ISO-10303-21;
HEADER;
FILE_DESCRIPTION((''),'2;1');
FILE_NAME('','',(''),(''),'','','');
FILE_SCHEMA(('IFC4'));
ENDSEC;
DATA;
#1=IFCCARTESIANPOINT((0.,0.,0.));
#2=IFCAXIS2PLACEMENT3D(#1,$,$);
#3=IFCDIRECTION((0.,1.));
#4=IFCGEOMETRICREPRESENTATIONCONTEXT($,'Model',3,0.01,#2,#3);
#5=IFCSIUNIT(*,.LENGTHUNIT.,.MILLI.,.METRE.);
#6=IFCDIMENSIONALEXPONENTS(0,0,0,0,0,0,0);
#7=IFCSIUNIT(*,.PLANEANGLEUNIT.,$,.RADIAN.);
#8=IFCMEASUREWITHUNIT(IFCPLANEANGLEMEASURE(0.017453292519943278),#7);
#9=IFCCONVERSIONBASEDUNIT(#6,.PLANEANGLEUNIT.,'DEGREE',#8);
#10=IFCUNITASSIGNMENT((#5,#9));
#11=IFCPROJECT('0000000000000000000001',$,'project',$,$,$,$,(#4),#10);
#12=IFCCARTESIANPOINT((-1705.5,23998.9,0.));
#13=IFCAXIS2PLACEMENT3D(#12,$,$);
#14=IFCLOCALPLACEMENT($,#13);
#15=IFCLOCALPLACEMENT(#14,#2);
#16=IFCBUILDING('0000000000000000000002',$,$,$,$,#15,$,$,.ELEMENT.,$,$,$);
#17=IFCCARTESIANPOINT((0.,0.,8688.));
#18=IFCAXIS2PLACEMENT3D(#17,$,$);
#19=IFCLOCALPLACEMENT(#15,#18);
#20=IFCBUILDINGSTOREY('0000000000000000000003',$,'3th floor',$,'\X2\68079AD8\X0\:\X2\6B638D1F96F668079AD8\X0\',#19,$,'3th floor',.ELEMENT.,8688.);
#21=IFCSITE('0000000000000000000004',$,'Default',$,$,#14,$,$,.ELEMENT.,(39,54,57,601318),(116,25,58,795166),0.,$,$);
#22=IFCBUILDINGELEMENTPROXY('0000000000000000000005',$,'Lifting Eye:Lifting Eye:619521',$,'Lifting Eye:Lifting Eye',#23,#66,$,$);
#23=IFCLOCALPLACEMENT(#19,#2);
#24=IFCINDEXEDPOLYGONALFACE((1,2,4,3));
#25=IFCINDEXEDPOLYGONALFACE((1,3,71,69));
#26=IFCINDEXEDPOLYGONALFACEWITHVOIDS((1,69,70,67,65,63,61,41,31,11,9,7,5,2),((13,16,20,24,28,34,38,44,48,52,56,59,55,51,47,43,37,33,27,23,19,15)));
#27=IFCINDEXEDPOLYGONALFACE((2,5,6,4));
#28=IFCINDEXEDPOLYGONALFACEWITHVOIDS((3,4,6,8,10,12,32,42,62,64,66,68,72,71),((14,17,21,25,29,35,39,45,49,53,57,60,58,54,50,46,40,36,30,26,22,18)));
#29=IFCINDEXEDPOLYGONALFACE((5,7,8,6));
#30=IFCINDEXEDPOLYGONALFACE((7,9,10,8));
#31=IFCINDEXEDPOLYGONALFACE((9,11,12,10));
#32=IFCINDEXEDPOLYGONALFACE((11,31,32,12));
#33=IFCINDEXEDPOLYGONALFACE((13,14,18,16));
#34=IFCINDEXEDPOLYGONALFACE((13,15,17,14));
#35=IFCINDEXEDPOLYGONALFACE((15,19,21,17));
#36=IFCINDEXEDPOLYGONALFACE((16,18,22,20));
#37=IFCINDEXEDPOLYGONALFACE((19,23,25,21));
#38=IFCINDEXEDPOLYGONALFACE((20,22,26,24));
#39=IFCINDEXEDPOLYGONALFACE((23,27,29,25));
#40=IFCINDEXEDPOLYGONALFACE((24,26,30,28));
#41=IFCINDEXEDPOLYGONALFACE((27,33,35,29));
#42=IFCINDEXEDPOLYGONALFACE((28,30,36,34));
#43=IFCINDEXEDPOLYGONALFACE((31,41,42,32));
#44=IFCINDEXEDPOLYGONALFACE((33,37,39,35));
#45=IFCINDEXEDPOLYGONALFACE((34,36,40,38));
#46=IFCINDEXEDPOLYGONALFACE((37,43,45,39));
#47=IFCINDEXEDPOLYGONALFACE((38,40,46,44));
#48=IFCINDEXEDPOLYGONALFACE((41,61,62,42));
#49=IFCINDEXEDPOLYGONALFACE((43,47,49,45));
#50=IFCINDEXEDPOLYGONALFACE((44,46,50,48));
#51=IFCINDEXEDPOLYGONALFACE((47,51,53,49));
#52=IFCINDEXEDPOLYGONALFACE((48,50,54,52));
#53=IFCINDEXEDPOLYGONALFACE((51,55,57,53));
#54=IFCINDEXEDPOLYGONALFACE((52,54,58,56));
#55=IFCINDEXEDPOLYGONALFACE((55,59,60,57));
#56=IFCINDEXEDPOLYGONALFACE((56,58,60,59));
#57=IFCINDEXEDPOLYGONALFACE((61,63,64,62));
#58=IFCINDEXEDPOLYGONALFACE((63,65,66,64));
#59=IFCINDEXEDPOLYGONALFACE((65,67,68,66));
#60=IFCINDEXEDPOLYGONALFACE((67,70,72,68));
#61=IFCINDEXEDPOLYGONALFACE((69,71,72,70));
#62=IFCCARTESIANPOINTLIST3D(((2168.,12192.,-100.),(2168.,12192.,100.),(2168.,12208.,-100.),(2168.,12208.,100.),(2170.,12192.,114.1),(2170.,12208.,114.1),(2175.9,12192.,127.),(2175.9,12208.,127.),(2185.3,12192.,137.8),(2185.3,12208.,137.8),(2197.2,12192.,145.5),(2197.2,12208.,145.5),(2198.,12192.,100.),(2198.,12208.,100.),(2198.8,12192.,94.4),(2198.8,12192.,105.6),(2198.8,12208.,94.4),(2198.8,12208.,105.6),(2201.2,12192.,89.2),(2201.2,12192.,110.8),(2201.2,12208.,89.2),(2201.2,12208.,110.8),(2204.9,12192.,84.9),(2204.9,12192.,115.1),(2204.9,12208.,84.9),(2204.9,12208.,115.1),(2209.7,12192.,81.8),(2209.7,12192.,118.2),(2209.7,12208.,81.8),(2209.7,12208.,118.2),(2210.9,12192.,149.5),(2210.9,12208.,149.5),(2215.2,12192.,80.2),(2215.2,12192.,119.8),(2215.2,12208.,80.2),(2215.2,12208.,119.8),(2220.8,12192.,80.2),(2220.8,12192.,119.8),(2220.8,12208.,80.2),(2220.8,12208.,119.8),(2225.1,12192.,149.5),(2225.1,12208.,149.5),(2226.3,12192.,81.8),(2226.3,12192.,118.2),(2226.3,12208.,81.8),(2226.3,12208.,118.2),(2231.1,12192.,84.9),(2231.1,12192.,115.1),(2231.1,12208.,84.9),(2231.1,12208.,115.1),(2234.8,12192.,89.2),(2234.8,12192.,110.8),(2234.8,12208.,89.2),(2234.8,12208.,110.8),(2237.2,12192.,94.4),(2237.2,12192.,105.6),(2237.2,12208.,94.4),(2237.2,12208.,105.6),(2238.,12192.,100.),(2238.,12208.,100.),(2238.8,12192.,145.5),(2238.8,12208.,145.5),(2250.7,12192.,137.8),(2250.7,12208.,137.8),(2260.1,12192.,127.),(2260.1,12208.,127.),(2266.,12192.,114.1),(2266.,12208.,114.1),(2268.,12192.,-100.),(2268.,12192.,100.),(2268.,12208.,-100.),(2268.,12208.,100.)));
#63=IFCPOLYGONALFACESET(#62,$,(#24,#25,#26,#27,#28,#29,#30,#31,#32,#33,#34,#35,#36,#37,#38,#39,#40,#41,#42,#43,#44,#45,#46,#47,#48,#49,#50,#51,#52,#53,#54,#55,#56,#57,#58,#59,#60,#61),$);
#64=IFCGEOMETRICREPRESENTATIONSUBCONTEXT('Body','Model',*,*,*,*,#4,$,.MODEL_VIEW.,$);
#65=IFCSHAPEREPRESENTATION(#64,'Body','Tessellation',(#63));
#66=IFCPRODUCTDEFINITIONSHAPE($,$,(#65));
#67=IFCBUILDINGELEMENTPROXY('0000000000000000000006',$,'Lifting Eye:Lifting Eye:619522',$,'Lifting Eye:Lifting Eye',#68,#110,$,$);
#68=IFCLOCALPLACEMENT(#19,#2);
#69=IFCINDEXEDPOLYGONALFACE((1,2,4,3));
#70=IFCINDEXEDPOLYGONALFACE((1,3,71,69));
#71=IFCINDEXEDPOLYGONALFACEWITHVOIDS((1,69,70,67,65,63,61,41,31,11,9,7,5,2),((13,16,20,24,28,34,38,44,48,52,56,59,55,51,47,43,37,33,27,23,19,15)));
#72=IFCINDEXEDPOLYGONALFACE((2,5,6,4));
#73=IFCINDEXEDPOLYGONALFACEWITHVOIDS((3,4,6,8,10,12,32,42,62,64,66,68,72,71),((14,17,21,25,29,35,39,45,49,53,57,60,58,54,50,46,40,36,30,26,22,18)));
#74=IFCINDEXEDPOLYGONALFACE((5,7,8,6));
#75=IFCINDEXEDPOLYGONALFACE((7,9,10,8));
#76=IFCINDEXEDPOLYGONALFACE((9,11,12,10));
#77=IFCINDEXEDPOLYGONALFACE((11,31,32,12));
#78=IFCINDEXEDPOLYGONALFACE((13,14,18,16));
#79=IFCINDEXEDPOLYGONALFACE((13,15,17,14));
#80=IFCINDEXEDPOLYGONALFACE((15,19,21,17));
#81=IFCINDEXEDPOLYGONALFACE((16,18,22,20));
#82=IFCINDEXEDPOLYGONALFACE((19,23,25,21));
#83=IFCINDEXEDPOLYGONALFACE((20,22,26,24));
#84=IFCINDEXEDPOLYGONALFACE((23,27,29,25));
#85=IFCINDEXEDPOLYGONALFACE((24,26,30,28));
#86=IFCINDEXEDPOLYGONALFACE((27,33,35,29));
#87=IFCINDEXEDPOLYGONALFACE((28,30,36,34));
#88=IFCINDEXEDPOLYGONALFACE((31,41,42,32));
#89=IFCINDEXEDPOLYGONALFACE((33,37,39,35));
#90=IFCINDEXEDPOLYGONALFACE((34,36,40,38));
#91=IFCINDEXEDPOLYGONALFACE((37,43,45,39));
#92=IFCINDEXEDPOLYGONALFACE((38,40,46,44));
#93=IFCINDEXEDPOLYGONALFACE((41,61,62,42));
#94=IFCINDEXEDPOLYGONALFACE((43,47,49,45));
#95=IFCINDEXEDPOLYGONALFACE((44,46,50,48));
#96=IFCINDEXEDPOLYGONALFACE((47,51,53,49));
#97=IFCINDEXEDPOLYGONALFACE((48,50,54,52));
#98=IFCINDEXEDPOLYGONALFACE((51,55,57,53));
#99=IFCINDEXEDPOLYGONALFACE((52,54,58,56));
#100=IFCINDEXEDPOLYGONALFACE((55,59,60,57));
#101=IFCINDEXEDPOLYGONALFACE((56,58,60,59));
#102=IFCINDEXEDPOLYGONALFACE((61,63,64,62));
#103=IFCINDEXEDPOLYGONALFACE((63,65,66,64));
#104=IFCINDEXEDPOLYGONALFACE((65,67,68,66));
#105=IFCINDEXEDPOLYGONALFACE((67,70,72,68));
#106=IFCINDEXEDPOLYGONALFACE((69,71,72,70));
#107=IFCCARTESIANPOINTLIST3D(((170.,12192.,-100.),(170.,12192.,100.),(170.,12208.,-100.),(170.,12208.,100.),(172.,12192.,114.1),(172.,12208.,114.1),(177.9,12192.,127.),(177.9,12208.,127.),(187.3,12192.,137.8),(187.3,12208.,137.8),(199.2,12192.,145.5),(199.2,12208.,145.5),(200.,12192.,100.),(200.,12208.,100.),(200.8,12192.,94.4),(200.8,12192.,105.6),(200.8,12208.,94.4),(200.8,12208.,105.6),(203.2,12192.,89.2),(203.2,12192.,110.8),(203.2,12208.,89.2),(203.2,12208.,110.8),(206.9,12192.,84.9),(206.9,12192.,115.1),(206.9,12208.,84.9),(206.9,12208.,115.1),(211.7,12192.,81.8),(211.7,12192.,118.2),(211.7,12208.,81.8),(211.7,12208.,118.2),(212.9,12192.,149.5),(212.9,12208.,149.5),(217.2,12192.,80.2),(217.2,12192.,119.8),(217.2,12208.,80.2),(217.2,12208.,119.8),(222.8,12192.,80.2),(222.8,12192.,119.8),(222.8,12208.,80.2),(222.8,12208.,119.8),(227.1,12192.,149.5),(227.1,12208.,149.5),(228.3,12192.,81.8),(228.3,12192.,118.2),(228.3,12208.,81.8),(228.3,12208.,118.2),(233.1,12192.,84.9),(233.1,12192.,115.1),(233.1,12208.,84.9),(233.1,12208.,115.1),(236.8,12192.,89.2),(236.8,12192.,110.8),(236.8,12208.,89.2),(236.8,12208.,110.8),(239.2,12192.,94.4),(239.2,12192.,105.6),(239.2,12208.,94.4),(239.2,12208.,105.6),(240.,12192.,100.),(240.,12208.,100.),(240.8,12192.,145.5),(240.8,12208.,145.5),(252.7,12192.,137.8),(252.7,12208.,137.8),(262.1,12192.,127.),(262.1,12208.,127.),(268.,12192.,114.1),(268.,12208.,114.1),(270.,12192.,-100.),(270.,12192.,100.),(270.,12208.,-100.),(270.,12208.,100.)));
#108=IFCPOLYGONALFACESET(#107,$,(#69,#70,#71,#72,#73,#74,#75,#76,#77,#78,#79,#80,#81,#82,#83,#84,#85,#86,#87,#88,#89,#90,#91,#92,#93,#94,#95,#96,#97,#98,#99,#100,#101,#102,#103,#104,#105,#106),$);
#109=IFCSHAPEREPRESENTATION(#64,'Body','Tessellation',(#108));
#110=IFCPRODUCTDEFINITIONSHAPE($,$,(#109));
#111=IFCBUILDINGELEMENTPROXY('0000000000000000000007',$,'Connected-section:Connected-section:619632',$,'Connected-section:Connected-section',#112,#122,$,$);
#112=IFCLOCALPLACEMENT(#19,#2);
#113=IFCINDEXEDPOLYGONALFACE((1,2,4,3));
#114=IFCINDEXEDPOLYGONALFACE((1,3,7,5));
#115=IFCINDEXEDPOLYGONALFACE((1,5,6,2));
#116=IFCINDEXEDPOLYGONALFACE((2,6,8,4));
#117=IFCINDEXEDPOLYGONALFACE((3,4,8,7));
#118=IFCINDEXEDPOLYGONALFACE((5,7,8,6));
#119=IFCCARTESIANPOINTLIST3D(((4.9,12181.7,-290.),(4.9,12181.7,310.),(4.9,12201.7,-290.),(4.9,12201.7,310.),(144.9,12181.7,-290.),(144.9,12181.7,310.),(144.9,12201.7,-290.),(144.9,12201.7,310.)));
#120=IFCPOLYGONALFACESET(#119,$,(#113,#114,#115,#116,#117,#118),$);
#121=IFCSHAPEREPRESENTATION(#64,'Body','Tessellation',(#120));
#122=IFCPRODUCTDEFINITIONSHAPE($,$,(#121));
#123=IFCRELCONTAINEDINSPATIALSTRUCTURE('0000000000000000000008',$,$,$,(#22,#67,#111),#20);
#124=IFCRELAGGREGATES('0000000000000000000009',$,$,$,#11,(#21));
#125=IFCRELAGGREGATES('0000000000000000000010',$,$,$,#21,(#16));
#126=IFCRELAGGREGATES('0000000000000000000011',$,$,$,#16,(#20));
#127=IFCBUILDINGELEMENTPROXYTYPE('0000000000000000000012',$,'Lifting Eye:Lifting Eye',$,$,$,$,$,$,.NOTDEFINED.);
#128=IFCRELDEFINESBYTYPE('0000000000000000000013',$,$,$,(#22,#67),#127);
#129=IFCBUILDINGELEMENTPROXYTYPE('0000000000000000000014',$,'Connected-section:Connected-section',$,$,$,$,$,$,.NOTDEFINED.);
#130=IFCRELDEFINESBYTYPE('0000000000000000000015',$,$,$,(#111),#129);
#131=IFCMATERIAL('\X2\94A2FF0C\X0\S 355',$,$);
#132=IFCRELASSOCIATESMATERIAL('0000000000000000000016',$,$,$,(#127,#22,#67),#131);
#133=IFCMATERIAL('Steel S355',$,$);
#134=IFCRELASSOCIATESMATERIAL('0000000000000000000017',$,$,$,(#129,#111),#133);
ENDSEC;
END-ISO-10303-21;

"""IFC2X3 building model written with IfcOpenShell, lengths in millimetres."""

from ifc_helpers import new_model, entity, si_unit, converted_unit, direction, frame, frame_2d, origin, place, context, subcontext, project, spatial, polyline, circle_curve, parameter, trimmed, segment, composite_curve, rectangle, outline, extrude, source, transform, mapped, material, type_object, type_shapes, element, save


model = new_model("IFC2X3")

# Units and contexts
model_context = context("Model", 3, precision=0.01, world=origin(), true_north=direction((0.0, 1.0)))
body_context = subcontext(model_context, "Body", "Model", "MODEL_VIEW")
ifc_project = project(units=[si_unit("LENGTHUNIT", "METRE", prefix="MILLI"), converted_unit("PLANEANGLEUNIT", "DEGREE", entity("IfcPlaneAngleMeasure", 0.017453292519943278), si_unit("PLANEANGLEUNIT", "RADIAN"), dimensions=[0, 0, 0, 0, 0, 0, 0])], contexts=[model_context])

# Site, building, storey
site_placement = place(None, frame((-1705.5, 23998.9, 0.0)))
site = spatial("IfcSite", under=ifc_project, at=site_placement, Name="Default", CompositionType="ELEMENT", RefLatitude=(39, 54, 57, 601318), RefLongitude=(116, 25, 58, 795166), RefElevation=0.0)
building_placement = place(site_placement, origin())
building = spatial("IfcBuilding", under=site, at=building_placement, CompositionType="ELEMENT")
storey_placement = place(building_placement, frame((0.0, 0.0, 8688.0)))
storey = spatial("IfcBuildingStorey", under=building, at=storey_placement, Name="3th floor", ObjectType="标高:正负零标高", LongName="3th floor", CompositionType="ELEMENT", Elevation=8688.0)

# Shared definitions
ifc_material_1 = material(Name="Steel S355")

# Building element proxies
ifc_material_2 = material(Name="钢，S 355")
building_element_proxy_type_1 = type_object("IfcBuildingElementProxyType", Name="Lifting Eye:Lifting Eye", PredefinedType="NOTDEFINED", material=ifc_material_2)
shared_shape_1 = source(origin(), body_context, "Body", "SweptSolid", [
    extrude(outline(composite_curve([segment(polyline([(-100.0, -50.0), (100.0, -50.0)]), True, "CONTINUOUS"), segment(polyline([(100.0, -50.0), (100.0, 50.0)]), True, "CONTINUOUS"), segment(polyline([(100.0, 50.0), (-100.0, 50.0)]), True, "CONTINUOUS"), segment(trimmed(circle_curve(frame_2d((-100.0, 0.0), x_axis=(0.0, -1.0)), 50.0), [parameter(180.0)], [parameter(0.0)], True, "PARAMETER"), True, "CONTINUOUS")], self_intersect=False), holes=[composite_curve([segment(trimmed(circle_curve(frame_2d((-100.0, 0.0), x_axis=(0.0, -1.0)), 20.0), [parameter(180.0)], [parameter(360.0)], True, "PARAMETER"), False, "CONTINUOUS"), segment(trimmed(circle_curve(frame_2d((-100.0, 0.0), x_axis=(0.0, -1.0)), 20.0), [parameter(0.0)], [parameter(180.0)], True, "PARAMETER"), False, "CONTINUOUS")], self_intersect=False)]), frame((0.0, 17.0, -17.0), z_axis=(0.0, 1.0, 0.0), x_axis=(0.0, 0.0, -1.0)), (0.0, 0.0, 1.0), 16.0),
])
type_shapes(building_element_proxy_type_1, [shared_shape_1])
for number, where, name in (
    (1, (2218.0, 12175.0, 17.0), "Lifting Eye:Lifting Eye:619521"),
    (2, (220.0, 12175.0, 17.0), "Lifting Eye:Lifting Eye:619522"),
):
    element("IfcBuildingElementProxy", number, at=place(storey_placement, frame(where)), inside=storey, type_object=building_element_proxy_type_1, material=ifc_material_2, Name=name, ObjectType="Lifting Eye:Lifting Eye", context=body_context, shape_type="MappedRepresentation", body=[
        mapped(shared_shape_1, transform((0.0, 0.0, 0.0), scale=1.0)),
    ])
building_element_proxy_type_2 = type_object("IfcBuildingElementProxyType", Name="Connected-section:Connected-section", PredefinedType="NOTDEFINED", material=ifc_material_1)
shared_shape_2 = source(origin(), body_context, "Body", "SweptSolid", [
    extrude(rectangle(XDim=20.0, YDim=140.0, at=frame_2d((0.0, 0.0), x_axis=(1.0, 0.0))), frame((70.0, 10.0, 0.0), z_axis=(0.0, 0.0, 1.0), x_axis=(0.0, 1.0, 0.0)), (0.0, 0.0, 1.0), 600.0),
])
type_shapes(building_element_proxy_type_2, [shared_shape_2])
proxy_1_placement = place(storey_placement, frame((4.9, 12181.7, -290.0)))
element("IfcBuildingElementProxy", 3, at=proxy_1_placement, inside=storey, type_object=building_element_proxy_type_2, material=ifc_material_1, Name="Connected-section:Connected-section:619632", ObjectType="Connected-section:Connected-section", context=body_context, shape_type="MappedRepresentation", body=[
    mapped(shared_shape_2, transform((0.0, 0.0, 0.0), scale=1.0)),
])

save(model, "model.ifc")
